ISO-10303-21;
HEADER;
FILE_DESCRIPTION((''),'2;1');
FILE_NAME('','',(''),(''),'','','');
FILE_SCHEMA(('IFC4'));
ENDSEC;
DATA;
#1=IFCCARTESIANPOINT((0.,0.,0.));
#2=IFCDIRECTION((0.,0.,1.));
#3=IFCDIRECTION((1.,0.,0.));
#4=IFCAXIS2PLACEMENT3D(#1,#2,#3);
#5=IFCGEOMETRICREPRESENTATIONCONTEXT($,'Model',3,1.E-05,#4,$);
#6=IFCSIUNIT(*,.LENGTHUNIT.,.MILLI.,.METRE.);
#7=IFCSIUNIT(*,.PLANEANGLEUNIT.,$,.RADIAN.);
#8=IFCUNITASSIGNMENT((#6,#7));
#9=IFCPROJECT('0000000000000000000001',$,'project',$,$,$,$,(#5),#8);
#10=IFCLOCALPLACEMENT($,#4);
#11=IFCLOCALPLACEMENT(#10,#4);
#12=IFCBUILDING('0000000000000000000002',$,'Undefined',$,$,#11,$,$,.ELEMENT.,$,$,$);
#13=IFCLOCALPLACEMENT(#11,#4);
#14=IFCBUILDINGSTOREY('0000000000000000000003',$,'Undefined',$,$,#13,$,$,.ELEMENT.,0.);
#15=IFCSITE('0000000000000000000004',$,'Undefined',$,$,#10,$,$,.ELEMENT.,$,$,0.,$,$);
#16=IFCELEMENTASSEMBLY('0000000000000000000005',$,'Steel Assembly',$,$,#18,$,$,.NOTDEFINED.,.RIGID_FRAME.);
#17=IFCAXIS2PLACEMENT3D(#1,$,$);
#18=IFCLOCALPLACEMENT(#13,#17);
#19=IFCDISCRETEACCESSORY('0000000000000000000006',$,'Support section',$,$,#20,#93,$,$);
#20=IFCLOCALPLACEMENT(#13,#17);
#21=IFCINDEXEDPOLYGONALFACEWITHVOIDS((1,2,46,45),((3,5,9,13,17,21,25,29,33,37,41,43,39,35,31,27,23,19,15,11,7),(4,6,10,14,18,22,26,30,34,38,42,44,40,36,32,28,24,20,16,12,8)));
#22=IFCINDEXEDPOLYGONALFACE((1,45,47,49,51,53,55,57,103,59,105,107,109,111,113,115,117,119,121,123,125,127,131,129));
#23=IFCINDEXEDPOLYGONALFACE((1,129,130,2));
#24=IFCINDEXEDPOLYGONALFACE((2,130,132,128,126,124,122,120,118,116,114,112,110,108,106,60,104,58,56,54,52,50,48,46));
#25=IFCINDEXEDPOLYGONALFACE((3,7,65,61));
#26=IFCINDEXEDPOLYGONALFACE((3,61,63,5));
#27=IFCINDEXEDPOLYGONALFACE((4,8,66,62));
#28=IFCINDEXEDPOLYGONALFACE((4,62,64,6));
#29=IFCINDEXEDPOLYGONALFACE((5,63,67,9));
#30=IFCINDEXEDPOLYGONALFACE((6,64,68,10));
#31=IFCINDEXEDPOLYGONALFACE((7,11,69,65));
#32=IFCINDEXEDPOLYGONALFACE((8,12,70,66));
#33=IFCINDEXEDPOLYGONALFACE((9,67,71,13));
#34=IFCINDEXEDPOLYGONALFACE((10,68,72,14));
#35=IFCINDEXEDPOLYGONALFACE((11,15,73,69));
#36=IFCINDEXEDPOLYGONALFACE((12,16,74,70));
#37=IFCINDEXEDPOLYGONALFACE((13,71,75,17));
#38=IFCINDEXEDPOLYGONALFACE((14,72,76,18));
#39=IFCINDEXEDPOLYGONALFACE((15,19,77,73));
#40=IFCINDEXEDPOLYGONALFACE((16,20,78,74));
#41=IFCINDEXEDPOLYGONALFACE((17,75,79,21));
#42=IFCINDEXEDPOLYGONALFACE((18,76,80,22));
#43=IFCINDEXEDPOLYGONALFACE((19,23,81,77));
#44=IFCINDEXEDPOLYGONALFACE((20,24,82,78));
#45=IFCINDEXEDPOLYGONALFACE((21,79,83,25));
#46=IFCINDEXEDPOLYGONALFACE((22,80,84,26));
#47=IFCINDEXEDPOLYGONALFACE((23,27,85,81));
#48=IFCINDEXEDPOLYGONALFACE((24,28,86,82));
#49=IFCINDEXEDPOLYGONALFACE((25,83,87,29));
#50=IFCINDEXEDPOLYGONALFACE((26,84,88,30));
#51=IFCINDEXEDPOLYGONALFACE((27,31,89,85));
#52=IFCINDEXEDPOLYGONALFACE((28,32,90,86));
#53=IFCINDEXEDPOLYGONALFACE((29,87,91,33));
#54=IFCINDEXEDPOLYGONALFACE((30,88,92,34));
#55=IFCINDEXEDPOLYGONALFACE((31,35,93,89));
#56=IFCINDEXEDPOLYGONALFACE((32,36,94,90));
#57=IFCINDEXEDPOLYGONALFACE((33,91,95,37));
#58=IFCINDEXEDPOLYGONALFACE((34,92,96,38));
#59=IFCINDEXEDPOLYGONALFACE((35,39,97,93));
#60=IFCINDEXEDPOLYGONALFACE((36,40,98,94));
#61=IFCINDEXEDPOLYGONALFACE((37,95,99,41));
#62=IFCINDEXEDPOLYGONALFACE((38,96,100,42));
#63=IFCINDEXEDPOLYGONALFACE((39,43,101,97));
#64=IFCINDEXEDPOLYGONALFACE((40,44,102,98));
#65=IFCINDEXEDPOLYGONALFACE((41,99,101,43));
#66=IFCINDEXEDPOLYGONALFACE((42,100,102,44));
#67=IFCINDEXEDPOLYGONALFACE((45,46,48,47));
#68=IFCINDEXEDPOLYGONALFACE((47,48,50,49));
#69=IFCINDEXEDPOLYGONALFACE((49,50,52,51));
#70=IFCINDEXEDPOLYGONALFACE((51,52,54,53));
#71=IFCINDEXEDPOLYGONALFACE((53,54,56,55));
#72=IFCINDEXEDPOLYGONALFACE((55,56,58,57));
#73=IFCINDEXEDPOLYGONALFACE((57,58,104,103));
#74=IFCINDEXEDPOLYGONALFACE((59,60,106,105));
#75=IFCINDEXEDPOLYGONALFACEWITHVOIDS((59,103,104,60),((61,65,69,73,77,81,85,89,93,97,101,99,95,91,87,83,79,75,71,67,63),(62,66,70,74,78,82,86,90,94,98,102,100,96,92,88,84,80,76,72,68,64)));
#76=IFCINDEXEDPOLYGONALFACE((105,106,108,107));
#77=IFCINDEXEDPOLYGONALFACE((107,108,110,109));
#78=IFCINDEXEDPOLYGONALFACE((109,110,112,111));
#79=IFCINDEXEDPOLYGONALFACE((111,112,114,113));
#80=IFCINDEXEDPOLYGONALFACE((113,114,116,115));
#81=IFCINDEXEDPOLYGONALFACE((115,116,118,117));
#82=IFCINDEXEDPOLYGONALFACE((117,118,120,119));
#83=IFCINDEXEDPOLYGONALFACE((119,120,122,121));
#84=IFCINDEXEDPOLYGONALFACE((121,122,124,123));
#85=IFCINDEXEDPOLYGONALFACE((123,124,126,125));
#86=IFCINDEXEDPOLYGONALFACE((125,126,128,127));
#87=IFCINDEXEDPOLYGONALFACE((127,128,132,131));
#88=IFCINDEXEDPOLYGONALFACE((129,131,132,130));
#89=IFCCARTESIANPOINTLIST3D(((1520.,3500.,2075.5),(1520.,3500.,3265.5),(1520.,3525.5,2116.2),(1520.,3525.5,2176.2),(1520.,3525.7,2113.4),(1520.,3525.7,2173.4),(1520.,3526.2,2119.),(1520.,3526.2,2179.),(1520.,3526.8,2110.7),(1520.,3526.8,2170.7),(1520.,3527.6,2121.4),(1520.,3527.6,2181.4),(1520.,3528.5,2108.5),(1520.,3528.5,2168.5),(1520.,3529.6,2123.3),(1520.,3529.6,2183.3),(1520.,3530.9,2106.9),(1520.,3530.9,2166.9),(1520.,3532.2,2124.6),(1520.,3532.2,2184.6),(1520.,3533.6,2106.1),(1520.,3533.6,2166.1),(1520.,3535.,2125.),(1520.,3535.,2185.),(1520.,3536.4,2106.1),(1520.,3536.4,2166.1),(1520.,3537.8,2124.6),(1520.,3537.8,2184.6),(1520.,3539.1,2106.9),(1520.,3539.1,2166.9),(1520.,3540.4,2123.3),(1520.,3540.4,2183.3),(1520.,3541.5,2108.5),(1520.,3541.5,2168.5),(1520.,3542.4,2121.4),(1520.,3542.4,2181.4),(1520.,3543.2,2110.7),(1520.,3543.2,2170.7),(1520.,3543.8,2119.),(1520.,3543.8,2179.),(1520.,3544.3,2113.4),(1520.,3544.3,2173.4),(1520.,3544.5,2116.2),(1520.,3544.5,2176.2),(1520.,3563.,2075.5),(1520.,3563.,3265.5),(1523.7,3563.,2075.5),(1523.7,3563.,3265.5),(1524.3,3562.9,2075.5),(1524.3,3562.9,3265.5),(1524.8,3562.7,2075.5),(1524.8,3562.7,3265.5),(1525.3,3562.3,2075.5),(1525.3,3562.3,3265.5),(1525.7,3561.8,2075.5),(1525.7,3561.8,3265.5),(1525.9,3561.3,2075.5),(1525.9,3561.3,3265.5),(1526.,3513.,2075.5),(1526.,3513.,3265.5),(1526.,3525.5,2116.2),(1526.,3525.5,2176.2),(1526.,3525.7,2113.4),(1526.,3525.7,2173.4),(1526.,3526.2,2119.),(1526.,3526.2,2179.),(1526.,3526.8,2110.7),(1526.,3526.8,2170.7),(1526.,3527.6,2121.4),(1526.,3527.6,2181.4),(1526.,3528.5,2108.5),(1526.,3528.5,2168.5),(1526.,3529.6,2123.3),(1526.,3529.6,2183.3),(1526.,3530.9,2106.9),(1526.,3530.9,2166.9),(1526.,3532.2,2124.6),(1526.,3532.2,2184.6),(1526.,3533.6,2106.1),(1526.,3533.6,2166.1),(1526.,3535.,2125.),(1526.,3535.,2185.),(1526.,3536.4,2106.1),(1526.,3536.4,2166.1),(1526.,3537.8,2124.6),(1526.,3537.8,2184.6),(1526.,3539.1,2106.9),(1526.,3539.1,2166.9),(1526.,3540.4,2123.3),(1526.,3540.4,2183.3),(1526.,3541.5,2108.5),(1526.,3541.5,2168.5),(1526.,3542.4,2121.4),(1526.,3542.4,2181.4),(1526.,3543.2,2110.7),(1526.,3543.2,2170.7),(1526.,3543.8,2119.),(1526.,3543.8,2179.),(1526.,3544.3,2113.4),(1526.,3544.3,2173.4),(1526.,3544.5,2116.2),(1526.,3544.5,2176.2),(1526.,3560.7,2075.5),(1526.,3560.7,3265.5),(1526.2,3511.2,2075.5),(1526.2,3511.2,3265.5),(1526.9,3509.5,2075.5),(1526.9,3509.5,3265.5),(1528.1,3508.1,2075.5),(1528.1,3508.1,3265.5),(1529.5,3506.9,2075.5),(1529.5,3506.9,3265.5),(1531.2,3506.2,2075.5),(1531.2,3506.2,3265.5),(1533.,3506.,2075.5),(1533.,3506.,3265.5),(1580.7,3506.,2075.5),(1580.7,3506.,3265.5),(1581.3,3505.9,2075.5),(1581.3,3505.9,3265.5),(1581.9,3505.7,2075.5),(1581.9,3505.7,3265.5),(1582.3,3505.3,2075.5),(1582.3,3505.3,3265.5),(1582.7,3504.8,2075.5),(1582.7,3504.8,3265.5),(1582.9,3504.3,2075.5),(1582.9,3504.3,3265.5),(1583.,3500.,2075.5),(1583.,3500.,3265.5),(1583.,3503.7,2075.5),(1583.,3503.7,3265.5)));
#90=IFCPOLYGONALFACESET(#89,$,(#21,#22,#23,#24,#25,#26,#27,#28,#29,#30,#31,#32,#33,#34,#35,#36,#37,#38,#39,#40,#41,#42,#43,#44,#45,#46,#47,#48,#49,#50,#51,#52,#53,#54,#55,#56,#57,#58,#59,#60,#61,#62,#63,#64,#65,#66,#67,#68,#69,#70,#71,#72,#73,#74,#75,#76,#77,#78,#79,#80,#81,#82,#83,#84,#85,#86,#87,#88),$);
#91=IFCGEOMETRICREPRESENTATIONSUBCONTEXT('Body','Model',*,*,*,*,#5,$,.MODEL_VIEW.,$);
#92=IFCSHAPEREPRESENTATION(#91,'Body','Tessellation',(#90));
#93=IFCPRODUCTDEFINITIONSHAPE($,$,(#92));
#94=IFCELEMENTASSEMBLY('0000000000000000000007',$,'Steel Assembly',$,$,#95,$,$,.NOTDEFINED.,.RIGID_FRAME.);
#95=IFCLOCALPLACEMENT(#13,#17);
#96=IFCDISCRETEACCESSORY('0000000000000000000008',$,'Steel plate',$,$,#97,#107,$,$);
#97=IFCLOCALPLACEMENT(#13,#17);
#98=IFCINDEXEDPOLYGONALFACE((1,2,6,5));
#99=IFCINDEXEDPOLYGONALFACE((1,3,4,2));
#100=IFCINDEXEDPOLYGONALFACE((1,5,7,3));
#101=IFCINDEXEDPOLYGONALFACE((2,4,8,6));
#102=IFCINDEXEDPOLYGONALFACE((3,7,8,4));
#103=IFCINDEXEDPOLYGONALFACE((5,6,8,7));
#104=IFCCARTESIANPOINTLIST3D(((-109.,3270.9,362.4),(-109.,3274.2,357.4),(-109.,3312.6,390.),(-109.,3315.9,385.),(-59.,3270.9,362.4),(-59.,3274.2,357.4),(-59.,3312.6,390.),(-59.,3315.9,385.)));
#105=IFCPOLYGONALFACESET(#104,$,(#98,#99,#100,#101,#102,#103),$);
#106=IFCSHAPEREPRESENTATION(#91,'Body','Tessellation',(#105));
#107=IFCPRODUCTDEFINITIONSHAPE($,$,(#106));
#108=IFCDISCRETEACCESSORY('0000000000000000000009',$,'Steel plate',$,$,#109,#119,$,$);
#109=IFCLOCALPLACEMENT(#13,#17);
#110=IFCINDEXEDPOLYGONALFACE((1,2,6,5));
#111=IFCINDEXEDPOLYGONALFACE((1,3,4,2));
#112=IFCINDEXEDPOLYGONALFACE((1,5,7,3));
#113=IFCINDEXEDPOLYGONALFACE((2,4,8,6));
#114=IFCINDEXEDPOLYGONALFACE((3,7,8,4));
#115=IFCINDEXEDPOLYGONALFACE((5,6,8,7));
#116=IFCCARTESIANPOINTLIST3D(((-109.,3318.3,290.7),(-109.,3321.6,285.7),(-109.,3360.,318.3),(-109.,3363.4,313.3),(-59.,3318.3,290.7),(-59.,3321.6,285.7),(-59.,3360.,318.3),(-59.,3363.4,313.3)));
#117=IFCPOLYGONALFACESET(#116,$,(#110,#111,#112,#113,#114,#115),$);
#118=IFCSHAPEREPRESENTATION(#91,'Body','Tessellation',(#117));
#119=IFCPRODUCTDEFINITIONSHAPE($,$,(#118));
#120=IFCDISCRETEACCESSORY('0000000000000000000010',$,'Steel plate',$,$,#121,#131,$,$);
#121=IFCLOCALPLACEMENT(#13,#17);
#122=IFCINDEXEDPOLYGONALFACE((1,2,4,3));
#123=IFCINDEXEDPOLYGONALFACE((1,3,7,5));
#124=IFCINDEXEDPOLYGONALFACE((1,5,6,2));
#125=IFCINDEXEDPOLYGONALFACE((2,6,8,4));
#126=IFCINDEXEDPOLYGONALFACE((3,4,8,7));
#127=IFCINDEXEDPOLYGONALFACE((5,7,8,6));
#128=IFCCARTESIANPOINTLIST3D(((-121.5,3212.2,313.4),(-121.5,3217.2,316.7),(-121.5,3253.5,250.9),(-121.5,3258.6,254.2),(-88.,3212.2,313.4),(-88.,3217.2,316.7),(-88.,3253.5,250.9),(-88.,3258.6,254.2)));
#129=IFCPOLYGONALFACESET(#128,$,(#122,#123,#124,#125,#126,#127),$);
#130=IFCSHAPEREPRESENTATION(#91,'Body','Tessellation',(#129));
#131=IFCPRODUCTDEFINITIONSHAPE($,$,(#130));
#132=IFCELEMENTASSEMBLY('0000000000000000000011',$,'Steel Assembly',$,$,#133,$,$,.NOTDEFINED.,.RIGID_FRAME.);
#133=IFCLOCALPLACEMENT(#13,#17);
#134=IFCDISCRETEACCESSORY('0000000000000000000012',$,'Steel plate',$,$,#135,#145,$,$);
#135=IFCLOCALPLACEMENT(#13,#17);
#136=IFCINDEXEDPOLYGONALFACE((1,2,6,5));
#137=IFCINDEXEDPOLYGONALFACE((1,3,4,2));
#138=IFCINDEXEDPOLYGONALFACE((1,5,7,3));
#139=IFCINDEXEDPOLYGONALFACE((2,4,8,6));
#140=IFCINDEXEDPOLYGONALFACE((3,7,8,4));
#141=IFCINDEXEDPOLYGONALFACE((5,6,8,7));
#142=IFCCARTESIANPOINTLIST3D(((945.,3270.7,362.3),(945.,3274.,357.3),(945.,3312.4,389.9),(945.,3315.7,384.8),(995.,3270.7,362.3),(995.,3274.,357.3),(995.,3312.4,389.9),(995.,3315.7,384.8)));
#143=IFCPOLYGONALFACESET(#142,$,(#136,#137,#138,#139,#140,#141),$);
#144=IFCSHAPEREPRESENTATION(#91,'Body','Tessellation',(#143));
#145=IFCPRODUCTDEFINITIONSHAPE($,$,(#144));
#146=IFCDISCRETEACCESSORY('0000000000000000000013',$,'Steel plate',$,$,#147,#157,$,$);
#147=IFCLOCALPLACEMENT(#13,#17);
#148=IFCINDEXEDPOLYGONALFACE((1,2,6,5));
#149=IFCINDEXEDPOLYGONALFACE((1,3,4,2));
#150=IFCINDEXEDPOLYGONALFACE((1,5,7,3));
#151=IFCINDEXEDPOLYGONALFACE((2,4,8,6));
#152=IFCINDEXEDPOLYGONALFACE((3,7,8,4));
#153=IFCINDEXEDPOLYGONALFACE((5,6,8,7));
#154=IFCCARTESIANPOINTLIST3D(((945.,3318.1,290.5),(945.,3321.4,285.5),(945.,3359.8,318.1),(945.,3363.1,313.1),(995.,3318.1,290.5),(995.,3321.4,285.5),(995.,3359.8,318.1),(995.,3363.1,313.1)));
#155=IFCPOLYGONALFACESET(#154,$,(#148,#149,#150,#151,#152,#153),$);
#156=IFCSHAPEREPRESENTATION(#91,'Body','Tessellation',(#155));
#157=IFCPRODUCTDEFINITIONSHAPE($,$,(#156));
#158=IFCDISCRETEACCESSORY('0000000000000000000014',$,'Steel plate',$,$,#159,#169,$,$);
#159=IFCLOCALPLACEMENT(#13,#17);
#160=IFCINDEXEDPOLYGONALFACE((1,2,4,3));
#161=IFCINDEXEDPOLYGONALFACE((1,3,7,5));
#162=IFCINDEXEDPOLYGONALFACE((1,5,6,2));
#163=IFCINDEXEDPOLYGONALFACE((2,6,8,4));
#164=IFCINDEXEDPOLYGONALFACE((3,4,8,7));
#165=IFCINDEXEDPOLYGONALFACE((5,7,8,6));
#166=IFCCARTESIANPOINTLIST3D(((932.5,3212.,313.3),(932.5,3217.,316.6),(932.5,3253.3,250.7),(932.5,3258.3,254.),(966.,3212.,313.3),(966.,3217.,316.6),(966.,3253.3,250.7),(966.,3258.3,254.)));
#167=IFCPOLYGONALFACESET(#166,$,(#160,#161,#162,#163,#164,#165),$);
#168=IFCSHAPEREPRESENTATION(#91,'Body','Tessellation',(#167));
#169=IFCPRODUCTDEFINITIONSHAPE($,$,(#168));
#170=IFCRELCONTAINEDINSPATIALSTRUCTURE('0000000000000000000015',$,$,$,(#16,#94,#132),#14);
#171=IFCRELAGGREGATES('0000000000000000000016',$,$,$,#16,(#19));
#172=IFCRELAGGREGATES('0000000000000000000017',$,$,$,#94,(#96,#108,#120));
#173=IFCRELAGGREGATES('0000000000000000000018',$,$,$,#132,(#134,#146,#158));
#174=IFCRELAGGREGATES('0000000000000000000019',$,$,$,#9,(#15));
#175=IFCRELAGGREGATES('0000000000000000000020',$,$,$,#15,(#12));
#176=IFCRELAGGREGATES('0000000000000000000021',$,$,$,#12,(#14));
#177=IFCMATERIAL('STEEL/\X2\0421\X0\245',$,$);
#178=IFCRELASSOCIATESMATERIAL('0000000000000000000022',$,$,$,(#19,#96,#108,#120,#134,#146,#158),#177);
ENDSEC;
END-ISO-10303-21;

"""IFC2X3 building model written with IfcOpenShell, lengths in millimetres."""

from ifc_helpers import new_model, si_unit, frame, origin_with_axes, origin_2d_with_axis, place, context, subcontext, project, spatial, polyline, circle, l_section, outline, extrude, source, transform, mapped, material, element, aggregate, save


model = new_model("IFC2X3")

# Units and contexts
model_context = context("Model", 3, precision=1e-05, world=origin_with_axes())
body_context = subcontext(model_context, "Body", "Model", "MODEL_VIEW")
ifc_project = project(units=[si_unit("LENGTHUNIT", "METRE", prefix="MILLI"), si_unit("PLANEANGLEUNIT", "RADIAN")], contexts=[model_context])

# Site, building, storey
site_placement = place(None, origin_with_axes())
site = spatial("IfcSite", under=ifc_project, at=site_placement, Name="Undefined", CompositionType="ELEMENT", RefElevation=0.0)
building_placement = place(site_placement, origin_with_axes())
building = spatial("IfcBuilding", under=site, at=building_placement, Name="Undefined", CompositionType="ELEMENT")
storey_placement = place(building_placement, origin_with_axes())
storey = spatial("IfcBuildingStorey", under=building, at=storey_placement, Name="Undefined", CompositionType="ELEMENT", Elevation=0.0)

# Element assembly, discrete accessory, opening
assembly_1_placement = place(storey_placement, origin_with_axes())
assembly_1 = element("IfcElementAssembly", 1, at=assembly_1_placement, inside=storey, Name="Steel Assembly", AssemblyPlace="NOTDEFINED", PredefinedType="RIGID_FRAME")
ifc_material_1 = material(Name="STEEL/С245")
discrete_accessory_1_placement = place(assembly_1_placement, frame((1551.5, 3531.5, 2075.5), z_axis=(0.0, 0.0, 1.0), x_axis=(1.0, 0.0, 0.0)))
discrete_accessory_1 = element("IfcDiscreteAccessory", 2, at=discrete_accessory_1_placement, material=ifc_material_1, Name="Support section", context=body_context, shape_type="SweptSolid", body=[
    extrude(l_section(Depth=63.0, Width=63.0, Thickness=6.0, FilletRadius=7.0, EdgeRadius=2.3, at=origin_2d_with_axis()), frame((0.0, 0.0, 1190.0), z_axis=(0.0, 0.0, -1.0), x_axis=(0.0, 1.0, 0.0)), (0.0, 0.0, 1.0), 1190.0),
])
shared_shape_1 = source(origin_with_axes(), body_context, "Body", "SweptSolid", [
    extrude(circle(Radius=9.5, at=origin_2d_with_axis()), frame((0.0, -0.1, 0.0), z_axis=(0.0, 1.0, 0.0), x_axis=(1.0, 0.0, 0.0)), (0.0, 0.0, 1.0), 6.2),
])
opening_1_placement = place(assembly_1_placement, frame((1520.0, 3535.0, 2115.5), z_axis=(0.0, 1.0, 0.0), x_axis=(0.0, 0.0, 1.0)))
element("IfcOpeningElement", 3, at=opening_1_placement, cuts=discrete_accessory_1, ObjectType="Opening", context=body_context, shape_type="MappedRepresentation", body=[
    mapped(shared_shape_1, transform((0.0, 0.0, 0.0))),
    mapped(shared_shape_1, transform((60.0, 0.0, 0.0))),
])
aggregate(assembly_1, [discrete_accessory_1])

# Element assemblies, discrete accessories, openings
assembly_2_placement = place(storey_placement, origin_with_axes())
assembly_2 = element("IfcElementAssembly", 4, at=assembly_2_placement, inside=storey, Name="Steel Assembly", AssemblyPlace="NOTDEFINED", PredefinedType="RIGID_FRAME")
discrete_accessory_2_placement = place(assembly_2_placement, frame((-59.0, 3272.6, 359.9), z_axis=(0.0, -0.551387, 0.83425), x_axis=(0.0, 0.83425, 0.551387)))
discrete_accessory_2 = element("IfcDiscreteAccessory", 5, at=discrete_accessory_2_placement, material=ifc_material_1, Name="Steel plate", context=body_context, shape_type="SweptSolid", body=[
    extrude(outline(polyline([(0.0, 0.0), (50.0, 0.0), (50.0, 50.0), (0.0, 50.0), (0.0, 0.0)])), frame((0.0, 0.0, -3.0), z_axis=(0.0, 0.0, 1.0), x_axis=(1.0, 0.0, 0.0)), (0.0, 0.0, 1.0), 6.0),
])
discrete_accessory_3_placement = place(assembly_2_placement, frame((-59.0, 3320.0, 288.2), z_axis=(0.0, -0.551387, 0.83425), x_axis=(0.0, 0.83425, 0.551387)))
discrete_accessory_3 = element("IfcDiscreteAccessory", 6, at=discrete_accessory_3_placement, material=ifc_material_1, Name="Steel plate", context=body_context, shape_type="SweptSolid", body=[
    extrude(outline(polyline([(0.0, 0.0), (50.0, 0.0), (50.0, 50.0), (0.0, 50.0), (0.0, 0.0)])), frame((0.0, 0.0, -3.0), z_axis=(0.0, 0.0, 1.0), x_axis=(1.0, 0.0, 0.0)), (0.0, 0.0, 1.0), 6.0),
])
discrete_accessory_4_placement = place(assembly_2_placement, frame((-121.5, 3256.1, 252.5), z_axis=(0.0, 0.83425, 0.551387), x_axis=(0.0, -0.551387, 0.83425)))
discrete_accessory_4 = element("IfcDiscreteAccessory", 7, at=discrete_accessory_4_placement, material=ifc_material_1, Name="Steel plate", context=body_context, shape_type="SweptSolid", body=[
    extrude(outline(polyline([(0.0, 0.0), (75.0, 0.0), (75.0, 75.0), (0.0, 75.0), (0.0, 0.0)])), frame((0.0, 0.0, -3.0), z_axis=(0.0, 0.0, 1.0), x_axis=(1.0, 0.0, 0.0)), (0.0, 0.0, 1.0), 6.0),
])
opening_2_placement = place(assembly_2_placement, frame((-121.5, 3256.1, 252.5), z_axis=(0.0, 0.83425, 0.551387), x_axis=(0.0, -0.551387, 0.83425)))
element("IfcOpeningElement", 8, at=opening_2_placement, cuts=discrete_accessory_4, ObjectType="Recess", context=body_context, shape_type="SweptSolid", body=[
    extrude(outline(polyline([(0.0, 0.0), (75.0, 0.0), (75.0, 150.0), (0.0, 150.0), (0.0, 0.0)])), frame((-37.5, 108.5, -6.0), z_axis=(0.0, 0.0, 1.0), x_axis=(0.0, -1.0, 0.0)), (0.0, 0.0, 1.0), 12.0),
])
aggregate(assembly_2, [discrete_accessory_2, discrete_accessory_3, discrete_accessory_4])
assembly_3_placement = place(storey_placement, origin_with_axes())
assembly_3 = element("IfcElementAssembly", 9, at=assembly_3_placement, inside=storey, Name="Steel Assembly", AssemblyPlace="NOTDEFINED", PredefinedType="RIGID_FRAME")
discrete_accessory_5_placement = place(assembly_3_placement, frame((995.0, 3272.3, 359.8), z_axis=(0.0, -0.551387, 0.83425), x_axis=(0.0, 0.83425, 0.551387)))
discrete_accessory_5 = element("IfcDiscreteAccessory", 10, at=discrete_accessory_5_placement, material=ifc_material_1, Name="Steel plate", context=body_context, shape_type="SweptSolid", body=[
    extrude(outline(polyline([(0.0, 0.0), (50.0, 0.0), (50.0, 50.0), (0.0, 50.0), (0.0, 0.0)])), frame((0.0, 0.0, -3.0), z_axis=(0.0, 0.0, 1.0), x_axis=(1.0, 0.0, 0.0)), (0.0, 0.0, 1.0), 6.0),
])
discrete_accessory_6_placement = place(assembly_3_placement, frame((995.0, 3319.8, 288.0), z_axis=(0.0, -0.551387, 0.83425), x_axis=(0.0, 0.83425, 0.551387)))
discrete_accessory_6 = element("IfcDiscreteAccessory", 11, at=discrete_accessory_6_placement, material=ifc_material_1, Name="Steel plate", context=body_context, shape_type="SweptSolid", body=[
    extrude(outline(polyline([(0.0, 0.0), (50.0, 0.0), (50.0, 50.0), (0.0, 50.0), (0.0, 0.0)])), frame((0.0, 0.0, -3.0), z_axis=(0.0, 0.0, 1.0), x_axis=(1.0, 0.0, 0.0)), (0.0, 0.0, 1.0), 6.0),
])
discrete_accessory_7_placement = place(assembly_3_placement, frame((932.5, 3255.8, 252.4), z_axis=(0.0, 0.83425, 0.551387), x_axis=(0.0, -0.551387, 0.83425)))
discrete_accessory_7 = element("IfcDiscreteAccessory", 12, at=discrete_accessory_7_placement, material=ifc_material_1, Name="Steel plate", context=body_context, shape_type="SweptSolid", body=[
    extrude(outline(polyline([(0.0, 0.0), (75.0, 0.0), (75.0, 75.0), (0.0, 75.0), (0.0, 0.0)])), frame((0.0, 0.0, -3.0), z_axis=(0.0, 0.0, 1.0), x_axis=(1.0, 0.0, 0.0)), (0.0, 0.0, 1.0), 6.0),
])
opening_3_placement = place(assembly_3_placement, frame((932.5, 3255.8, 252.4), z_axis=(0.0, 0.83425, 0.551387), x_axis=(0.0, -0.551387, 0.83425)))
element("IfcOpeningElement", 13, at=opening_3_placement, cuts=discrete_accessory_7, ObjectType="Recess", context=body_context, shape_type="SweptSolid", body=[
    extrude(outline(polyline([(0.0, 0.0), (75.0, 0.0), (75.0, 150.0), (0.0, 150.0), (0.0, 0.0)])), frame((-37.5, 108.5, -6.0), z_axis=(0.0, 0.0, 1.0), x_axis=(0.0, -1.0, 0.0)), (0.0, 0.0, 1.0), 12.0),
])
aggregate(assembly_3, [discrete_accessory_5, discrete_accessory_6, discrete_accessory_7])

save(model, "model.ifc")
